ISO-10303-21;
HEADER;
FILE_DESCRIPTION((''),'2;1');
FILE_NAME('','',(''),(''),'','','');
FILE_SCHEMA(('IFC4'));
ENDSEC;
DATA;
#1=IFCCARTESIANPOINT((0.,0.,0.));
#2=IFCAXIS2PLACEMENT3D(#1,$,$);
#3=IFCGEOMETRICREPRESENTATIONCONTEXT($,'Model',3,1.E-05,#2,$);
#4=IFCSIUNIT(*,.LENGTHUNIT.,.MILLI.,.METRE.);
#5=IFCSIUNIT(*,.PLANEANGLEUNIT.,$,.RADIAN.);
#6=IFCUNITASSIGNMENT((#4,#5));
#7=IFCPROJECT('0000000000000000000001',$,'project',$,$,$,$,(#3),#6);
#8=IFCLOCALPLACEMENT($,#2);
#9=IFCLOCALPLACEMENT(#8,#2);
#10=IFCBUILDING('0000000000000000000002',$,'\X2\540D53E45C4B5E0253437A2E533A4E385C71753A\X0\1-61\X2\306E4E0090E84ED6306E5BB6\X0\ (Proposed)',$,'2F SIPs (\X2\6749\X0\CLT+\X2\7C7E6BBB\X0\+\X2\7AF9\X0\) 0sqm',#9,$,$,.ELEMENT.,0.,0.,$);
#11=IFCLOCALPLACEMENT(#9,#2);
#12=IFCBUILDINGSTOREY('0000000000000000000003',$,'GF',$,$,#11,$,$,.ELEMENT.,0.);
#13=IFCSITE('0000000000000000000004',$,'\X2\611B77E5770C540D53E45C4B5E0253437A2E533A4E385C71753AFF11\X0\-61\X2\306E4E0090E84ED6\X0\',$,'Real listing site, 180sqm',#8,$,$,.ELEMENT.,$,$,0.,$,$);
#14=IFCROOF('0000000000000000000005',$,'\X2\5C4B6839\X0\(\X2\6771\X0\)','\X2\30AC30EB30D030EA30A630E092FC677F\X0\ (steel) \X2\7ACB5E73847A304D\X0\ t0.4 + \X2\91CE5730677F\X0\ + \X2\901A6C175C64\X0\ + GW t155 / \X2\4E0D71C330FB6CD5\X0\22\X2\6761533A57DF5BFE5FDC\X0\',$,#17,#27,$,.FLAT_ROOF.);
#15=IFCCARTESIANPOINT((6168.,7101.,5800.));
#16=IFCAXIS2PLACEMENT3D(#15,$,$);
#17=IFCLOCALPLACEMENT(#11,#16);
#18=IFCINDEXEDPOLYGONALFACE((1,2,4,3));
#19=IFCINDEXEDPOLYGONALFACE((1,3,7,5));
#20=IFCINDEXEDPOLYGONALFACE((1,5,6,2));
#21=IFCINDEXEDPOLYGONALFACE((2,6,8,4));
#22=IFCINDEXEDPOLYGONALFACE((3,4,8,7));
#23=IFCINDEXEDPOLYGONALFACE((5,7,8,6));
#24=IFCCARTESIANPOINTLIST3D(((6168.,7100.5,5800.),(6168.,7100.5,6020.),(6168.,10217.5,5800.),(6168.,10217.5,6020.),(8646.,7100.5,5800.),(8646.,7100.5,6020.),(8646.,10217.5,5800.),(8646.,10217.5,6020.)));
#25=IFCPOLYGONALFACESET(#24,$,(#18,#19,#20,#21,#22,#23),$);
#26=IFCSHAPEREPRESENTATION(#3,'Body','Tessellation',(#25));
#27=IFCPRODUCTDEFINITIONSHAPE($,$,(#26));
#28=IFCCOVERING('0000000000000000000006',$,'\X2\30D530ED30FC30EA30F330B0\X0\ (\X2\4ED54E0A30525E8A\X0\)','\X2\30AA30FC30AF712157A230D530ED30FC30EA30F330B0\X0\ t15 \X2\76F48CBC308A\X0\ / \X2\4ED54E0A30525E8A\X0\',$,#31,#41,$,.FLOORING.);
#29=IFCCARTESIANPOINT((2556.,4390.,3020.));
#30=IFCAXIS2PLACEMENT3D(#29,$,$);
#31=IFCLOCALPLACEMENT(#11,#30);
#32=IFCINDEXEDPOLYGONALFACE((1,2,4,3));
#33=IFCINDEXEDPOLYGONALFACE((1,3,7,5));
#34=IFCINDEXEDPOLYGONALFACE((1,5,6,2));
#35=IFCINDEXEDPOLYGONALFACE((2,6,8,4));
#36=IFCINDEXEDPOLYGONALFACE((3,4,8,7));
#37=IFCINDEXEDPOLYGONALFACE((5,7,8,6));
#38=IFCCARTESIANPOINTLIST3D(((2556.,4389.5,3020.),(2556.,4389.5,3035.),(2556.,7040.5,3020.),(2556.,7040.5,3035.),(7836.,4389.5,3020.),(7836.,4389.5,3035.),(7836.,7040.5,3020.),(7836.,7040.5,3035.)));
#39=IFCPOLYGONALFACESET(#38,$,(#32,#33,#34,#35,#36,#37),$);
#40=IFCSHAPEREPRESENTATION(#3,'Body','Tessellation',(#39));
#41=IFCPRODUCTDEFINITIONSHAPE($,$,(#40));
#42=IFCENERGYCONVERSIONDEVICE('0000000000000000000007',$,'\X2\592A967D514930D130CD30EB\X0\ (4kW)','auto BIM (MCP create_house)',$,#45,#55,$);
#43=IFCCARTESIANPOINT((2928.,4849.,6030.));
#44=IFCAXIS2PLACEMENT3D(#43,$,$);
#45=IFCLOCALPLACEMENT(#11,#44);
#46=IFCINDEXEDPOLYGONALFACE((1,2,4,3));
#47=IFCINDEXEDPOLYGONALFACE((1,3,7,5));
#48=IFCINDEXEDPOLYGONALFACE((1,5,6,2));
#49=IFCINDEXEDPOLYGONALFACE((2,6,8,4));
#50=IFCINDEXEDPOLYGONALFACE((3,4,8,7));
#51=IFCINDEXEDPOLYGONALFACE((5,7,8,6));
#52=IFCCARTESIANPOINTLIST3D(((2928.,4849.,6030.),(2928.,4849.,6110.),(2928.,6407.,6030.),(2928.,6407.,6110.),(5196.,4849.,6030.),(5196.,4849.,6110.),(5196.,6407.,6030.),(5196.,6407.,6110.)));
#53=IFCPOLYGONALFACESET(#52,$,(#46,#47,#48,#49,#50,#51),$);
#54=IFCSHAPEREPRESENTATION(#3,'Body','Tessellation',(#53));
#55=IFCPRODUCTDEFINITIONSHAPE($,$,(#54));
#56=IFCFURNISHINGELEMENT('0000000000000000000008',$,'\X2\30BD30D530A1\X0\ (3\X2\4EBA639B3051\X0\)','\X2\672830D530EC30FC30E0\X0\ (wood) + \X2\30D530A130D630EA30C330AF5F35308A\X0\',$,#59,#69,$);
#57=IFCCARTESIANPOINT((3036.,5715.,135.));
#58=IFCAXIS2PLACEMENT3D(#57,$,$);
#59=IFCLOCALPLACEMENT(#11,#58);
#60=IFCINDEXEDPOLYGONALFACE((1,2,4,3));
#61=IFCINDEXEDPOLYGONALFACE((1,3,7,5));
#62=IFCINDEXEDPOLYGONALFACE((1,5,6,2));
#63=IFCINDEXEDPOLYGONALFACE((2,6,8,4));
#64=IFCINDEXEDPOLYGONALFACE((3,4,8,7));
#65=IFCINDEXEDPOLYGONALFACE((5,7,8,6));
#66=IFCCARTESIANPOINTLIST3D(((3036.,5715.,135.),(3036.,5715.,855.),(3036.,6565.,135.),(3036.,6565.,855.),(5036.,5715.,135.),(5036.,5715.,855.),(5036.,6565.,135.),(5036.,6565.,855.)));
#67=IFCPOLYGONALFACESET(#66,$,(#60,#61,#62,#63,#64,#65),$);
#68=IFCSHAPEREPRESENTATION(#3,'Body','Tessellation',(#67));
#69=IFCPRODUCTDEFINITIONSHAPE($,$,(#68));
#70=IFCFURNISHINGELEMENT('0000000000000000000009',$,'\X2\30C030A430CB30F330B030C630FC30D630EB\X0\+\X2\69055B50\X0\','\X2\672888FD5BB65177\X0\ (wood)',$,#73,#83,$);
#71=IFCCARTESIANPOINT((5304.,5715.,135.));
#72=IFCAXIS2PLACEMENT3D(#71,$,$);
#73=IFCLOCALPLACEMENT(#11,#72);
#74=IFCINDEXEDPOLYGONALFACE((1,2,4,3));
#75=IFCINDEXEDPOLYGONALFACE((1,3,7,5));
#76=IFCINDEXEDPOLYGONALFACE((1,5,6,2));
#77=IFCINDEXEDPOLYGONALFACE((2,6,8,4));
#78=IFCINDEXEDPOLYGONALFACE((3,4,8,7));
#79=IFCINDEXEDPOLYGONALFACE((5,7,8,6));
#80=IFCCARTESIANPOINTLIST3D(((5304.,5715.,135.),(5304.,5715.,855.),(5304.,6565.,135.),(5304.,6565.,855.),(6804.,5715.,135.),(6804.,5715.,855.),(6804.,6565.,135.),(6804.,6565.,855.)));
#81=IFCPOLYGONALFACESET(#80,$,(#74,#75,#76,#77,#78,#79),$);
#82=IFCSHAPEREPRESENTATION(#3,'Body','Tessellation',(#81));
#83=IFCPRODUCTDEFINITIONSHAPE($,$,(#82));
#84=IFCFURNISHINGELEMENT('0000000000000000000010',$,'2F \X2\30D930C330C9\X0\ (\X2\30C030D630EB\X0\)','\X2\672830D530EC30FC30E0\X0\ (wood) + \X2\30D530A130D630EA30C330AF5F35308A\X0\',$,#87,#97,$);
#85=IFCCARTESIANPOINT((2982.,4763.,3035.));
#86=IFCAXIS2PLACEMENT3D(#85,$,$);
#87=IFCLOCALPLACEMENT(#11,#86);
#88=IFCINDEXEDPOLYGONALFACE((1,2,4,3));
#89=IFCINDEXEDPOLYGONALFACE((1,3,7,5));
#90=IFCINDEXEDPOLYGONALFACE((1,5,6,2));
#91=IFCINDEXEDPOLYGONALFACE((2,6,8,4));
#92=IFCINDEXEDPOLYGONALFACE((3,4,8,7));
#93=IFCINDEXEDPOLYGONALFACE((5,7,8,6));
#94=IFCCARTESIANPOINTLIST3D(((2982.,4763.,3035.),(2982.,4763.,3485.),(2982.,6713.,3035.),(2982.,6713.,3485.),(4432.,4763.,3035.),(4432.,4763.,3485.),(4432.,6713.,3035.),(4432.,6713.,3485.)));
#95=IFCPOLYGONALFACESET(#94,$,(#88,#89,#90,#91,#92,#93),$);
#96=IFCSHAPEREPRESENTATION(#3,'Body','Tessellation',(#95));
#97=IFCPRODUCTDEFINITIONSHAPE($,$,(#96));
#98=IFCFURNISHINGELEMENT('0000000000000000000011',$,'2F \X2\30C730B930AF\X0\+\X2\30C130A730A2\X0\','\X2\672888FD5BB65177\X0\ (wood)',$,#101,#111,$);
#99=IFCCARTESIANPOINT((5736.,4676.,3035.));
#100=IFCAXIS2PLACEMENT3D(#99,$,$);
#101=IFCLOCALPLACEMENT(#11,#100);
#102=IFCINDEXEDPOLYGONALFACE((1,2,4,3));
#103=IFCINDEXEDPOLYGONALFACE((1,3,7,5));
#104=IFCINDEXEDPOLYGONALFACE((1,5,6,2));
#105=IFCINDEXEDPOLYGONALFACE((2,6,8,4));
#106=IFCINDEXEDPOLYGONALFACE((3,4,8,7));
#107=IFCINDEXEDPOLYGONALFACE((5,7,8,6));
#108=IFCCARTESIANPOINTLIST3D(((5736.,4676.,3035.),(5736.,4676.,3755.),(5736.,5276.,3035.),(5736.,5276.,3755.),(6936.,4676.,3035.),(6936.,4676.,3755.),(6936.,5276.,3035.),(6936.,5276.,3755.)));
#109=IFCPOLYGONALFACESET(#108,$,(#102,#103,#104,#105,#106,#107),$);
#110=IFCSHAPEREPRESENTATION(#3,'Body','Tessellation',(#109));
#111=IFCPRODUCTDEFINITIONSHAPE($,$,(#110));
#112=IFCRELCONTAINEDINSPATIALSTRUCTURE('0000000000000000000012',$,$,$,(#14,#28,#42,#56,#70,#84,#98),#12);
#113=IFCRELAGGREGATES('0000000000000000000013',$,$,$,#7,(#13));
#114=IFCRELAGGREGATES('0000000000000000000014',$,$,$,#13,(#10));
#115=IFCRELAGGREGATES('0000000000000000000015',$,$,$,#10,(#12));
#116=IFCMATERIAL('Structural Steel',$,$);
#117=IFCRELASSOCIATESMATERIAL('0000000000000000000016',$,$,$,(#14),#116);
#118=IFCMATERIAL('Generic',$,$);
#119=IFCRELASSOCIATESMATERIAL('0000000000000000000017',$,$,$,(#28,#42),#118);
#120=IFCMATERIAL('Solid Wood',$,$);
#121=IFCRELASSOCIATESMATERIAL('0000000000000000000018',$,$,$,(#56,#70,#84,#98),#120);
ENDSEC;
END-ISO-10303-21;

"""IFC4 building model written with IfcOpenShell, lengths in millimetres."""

from ifc_helpers import new_model, si_unit, frame, frame_2d, origin, place, context, project, spatial, rectangle, extrude, material, element, save


model = new_model("IFC4")

# Units and contexts
model_context = context("Model", 3, precision=1e-05, world=origin())
ifc_project = project(units=[si_unit("LENGTHUNIT", "METRE", prefix="MILLI"), si_unit("PLANEANGLEUNIT", "RADIAN")], contexts=[model_context])

# Site, building, storey
site_placement = place(None, origin())
site = spatial("IfcSite", under=ifc_project, at=site_placement, Name="愛知県名古屋市千種区丸山町１-61の一部他", ObjectType="Real listing site, 180sqm", CompositionType="ELEMENT", RefElevation=0.0)
building_placement = place(site_placement, origin())
building = spatial("IfcBuilding", under=site, at=building_placement, Name="名古屋市千種区丸山町1-61の一部他の家 (Proposed)", ObjectType="2F SIPs (杉CLT+籾殻+竹) 0sqm", CompositionType="ELEMENT", ElevationOfRefHeight=0.0, ElevationOfTerrain=0.0)
storey_placement = place(building_placement, origin())
storey = spatial("IfcBuildingStorey", under=building, at=storey_placement, Name="GF", CompositionType="ELEMENT", Elevation=0.0)

# Shared definitions
ifc_material_1 = material(Name="Solid Wood")

# Roof
ifc_material_2 = material(Name="Structural Steel")
roof_1_placement = place(storey_placement, frame((6168.0, 7101.0, 5800.0)))
element("IfcRoof", 1, at=roof_1_placement, inside=storey, material=ifc_material_2, Name="屋根(東)", Description="ガルバリウム鋼板 (steel) 立平葺き t0.4 + 野地板 + 通気層 + GW t155 / 不燃・法22条区域対応", PredefinedType="FLAT_ROOF", context=model_context, shape_type="SweptSolid", body=[
    extrude(rectangle(XDim=2478.0, YDim=3117.0, at=frame_2d((1239.0, 1558.0))), frame((6168.0, 7101.0, 5800.0)), (0.0, 0.0, 1.0), 220.0),
])

# Covering
ifc_material_3 = material(Name="Generic")
covering_placement = place(storey_placement, frame((2556.0, 4390.0, 3020.0)))
element("IfcCovering", 2, at=covering_placement, inside=storey, material=ifc_material_3, Name="フローリング (仕上げ床)", Description="オーク無垢フローリング t15 直貼り / 仕上げ床", PredefinedType="FLOORING", context=model_context, shape_type="SweptSolid", body=[
    extrude(rectangle(XDim=5280.0, YDim=2651.0, at=frame_2d((2640.0, 1325.0))), frame((2556.0, 4390.0, 3020.0)), (0.0, 0.0, 1.0), 15.0),
])

# Energy conversion device
energy_conversion_device_placement = place(storey_placement, frame((2928.0, 4849.0, 6030.0)))
element("IfcEnergyConversionDevice", 3, at=energy_conversion_device_placement, inside=storey, material=ifc_material_3, Name="太陽光パネル (4kW)", Description="auto BIM (MCP create_house)", context=model_context, shape_type="SweptSolid", body=[
    extrude(rectangle(XDim=2268.0, YDim=1558.0, at=frame_2d((1134.0, 779.0))), frame((2928.0, 4849.0, 6030.0)), (0.0, 0.0, 1.0), 80.0),
])

# Furnishing elements
furnishing_1_placement = place(storey_placement, frame((3036.0, 5715.0, 135.0)))
element("IfcFurnishingElement", 4, at=furnishing_1_placement, inside=storey, material=ifc_material_1, Name="ソファ (3人掛け)", Description="木フレーム (wood) + ファブリック張り", context=model_context, shape_type="SweptSolid", body=[
    extrude(rectangle(XDim=2000.0, YDim=850.0, at=frame_2d((1000.0, 425.0))), frame((3036.0, 5715.0, 135.0)), (0.0, 0.0, 1.0), 720.0),
])
furnishing_2_placement = place(storey_placement, frame((5304.0, 5715.0, 135.0)))
element("IfcFurnishingElement", 5, at=furnishing_2_placement, inside=storey, material=ifc_material_1, Name="ダイニングテーブル+椅子", Description="木製家具 (wood)", context=model_context, shape_type="SweptSolid", body=[
    extrude(rectangle(XDim=1500.0, YDim=850.0, at=frame_2d((750.0, 425.0))), frame((5304.0, 5715.0, 135.0)), (0.0, 0.0, 1.0), 720.0),
])
furnishing_3_placement = place(storey_placement, frame((2982.0, 4763.0, 3035.0)))
element("IfcFurnishingElement", 6, at=furnishing_3_placement, inside=storey, material=ifc_material_1, Name="2F ベッド (ダブル)", Description="木フレーム (wood) + ファブリック張り", context=model_context, shape_type="SweptSolid", body=[
    extrude(rectangle(XDim=1450.0, YDim=1950.0, at=frame_2d((725.0, 975.0))), frame((2982.0, 4763.0, 3035.0)), (0.0, 0.0, 1.0), 450.0),
])
furnishing_4_placement = place(storey_placement, frame((5736.0, 4676.0, 3035.0)))
element("IfcFurnishingElement", 7, at=furnishing_4_placement, inside=storey, material=ifc_material_1, Name="2F デスク+チェア", Description="木製家具 (wood)", context=model_context, shape_type="SweptSolid", body=[
    extrude(rectangle(XDim=1200.0, YDim=600.0, at=frame_2d((600.0, 300.0))), frame((5736.0, 4676.0, 3035.0)), (0.0, 0.0, 1.0), 720.0),
])

save(model, "model.ifc")
